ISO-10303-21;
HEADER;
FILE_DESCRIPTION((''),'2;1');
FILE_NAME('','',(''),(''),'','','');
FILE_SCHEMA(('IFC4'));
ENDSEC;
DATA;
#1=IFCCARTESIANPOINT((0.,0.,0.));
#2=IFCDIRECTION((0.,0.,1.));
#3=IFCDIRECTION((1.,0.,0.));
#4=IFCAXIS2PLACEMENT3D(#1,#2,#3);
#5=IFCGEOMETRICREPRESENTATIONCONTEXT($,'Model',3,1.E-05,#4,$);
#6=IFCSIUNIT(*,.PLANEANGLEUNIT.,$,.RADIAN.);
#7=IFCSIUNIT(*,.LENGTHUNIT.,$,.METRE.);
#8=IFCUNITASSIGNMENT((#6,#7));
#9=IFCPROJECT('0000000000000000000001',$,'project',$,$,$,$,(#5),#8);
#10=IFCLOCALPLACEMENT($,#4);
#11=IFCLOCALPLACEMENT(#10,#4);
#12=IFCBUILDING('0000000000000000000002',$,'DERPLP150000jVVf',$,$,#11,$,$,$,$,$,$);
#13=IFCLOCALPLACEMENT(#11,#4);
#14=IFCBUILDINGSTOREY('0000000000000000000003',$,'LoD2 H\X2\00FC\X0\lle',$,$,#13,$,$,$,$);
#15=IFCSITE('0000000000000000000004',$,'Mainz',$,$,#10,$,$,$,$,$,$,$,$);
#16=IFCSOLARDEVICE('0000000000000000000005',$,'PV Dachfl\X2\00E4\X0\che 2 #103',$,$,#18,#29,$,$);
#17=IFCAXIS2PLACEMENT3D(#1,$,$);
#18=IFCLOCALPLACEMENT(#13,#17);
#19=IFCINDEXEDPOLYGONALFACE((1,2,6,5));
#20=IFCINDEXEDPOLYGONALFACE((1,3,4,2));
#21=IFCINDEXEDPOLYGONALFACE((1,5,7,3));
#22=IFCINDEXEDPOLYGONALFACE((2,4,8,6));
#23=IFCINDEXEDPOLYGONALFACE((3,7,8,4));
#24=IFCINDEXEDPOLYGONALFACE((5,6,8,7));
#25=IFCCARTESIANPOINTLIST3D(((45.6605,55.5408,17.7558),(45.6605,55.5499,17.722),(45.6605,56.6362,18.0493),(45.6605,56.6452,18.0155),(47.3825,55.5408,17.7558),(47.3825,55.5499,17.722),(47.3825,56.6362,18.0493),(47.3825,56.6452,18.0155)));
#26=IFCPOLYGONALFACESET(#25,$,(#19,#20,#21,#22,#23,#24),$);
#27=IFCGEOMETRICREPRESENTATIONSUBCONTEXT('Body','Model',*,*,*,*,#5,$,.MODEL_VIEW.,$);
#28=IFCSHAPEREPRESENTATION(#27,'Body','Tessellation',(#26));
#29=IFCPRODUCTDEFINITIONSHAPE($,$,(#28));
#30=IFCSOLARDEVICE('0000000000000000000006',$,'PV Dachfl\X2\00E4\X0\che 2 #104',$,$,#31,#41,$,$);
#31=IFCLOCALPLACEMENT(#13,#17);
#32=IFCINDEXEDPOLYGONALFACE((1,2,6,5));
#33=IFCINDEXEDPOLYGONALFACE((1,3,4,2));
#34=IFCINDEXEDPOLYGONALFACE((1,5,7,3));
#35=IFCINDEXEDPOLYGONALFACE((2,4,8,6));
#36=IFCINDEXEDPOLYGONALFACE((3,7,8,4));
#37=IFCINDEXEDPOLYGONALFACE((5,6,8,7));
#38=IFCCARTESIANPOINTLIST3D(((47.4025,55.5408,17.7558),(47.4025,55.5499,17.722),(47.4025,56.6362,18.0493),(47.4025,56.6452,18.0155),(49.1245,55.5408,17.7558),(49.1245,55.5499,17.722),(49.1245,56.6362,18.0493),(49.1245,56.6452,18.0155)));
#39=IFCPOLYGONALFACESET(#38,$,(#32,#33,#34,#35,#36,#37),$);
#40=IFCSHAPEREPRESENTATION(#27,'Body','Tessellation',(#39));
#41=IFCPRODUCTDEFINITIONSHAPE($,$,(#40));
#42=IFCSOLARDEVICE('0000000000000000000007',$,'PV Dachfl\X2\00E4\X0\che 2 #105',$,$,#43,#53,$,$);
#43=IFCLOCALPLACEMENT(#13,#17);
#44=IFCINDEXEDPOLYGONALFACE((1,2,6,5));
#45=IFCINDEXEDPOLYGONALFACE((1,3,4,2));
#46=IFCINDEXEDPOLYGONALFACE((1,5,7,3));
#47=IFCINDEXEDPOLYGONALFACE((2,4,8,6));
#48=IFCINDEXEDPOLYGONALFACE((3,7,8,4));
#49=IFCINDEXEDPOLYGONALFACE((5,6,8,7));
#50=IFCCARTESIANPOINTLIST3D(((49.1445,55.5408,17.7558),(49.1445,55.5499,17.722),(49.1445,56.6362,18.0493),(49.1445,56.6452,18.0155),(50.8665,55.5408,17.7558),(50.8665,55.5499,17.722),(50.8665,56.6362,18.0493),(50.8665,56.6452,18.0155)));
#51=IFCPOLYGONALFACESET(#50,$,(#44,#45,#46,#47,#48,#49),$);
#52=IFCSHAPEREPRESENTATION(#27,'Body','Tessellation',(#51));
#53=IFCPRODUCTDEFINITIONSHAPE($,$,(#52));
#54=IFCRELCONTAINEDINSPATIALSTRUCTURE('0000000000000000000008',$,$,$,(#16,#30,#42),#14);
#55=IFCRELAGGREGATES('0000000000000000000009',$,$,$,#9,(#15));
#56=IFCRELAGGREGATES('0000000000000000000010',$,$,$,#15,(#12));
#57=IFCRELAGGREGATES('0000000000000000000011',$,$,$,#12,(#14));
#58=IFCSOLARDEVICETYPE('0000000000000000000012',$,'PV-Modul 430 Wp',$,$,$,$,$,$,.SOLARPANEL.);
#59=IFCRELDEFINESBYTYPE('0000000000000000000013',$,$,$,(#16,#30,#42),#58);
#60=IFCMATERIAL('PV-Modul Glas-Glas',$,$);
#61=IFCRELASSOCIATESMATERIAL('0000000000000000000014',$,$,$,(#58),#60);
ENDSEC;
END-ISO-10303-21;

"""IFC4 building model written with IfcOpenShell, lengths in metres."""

from ifc_helpers import new_model, si_unit, frame, frame_2d, origin, origin_with_axes, place, context, subcontext, project, spatial, rectangle, extrude, source, transform, mapped, material, type_object, type_shapes, element, save


model = new_model("IFC4")

# Units and contexts
model_context = context("Model", 3, precision=1e-05, world=origin_with_axes())
body_context = subcontext(model_context, "Body", "Model", "MODEL_VIEW")
ifc_project = project(units=[si_unit("PLANEANGLEUNIT", "RADIAN"), si_unit("LENGTHUNIT", "METRE")], contexts=[model_context])

# Site, building, storey
site_placement = place(None, origin_with_axes())
site = spatial("IfcSite", under=ifc_project, at=site_placement, Name="Mainz")
building_placement = place(site_placement, origin_with_axes())
building = spatial("IfcBuilding", under=site, at=building_placement, Name="DERPLP150000jVVf")
storey_placement = place(building_placement, origin_with_axes())
storey = spatial("IfcBuildingStorey", under=building, at=storey_placement, Name="LoD2 Hülle")

# Solar devices
ifc_material = material(Name="PV-Modul Glas-Glas")
solar_device_type = type_object("IfcSolarDeviceType", Name="PV-Modul 430 Wp", PredefinedType="SOLARPANEL", material=ifc_material)
shared_shape = source(origin_with_axes(), body_context, "Body", "SweptSolid", [
    extrude(rectangle(XDim=1.722, YDim=1.134, at=frame_2d((0.861, 0.567))), origin(), (0.0, 0.0, 1.0), 0.035),
])
type_shapes(solar_device_type, [shared_shape])
for number, where, z_axis, x_axis, name in (
    (1, (45.6605, 55.5499, 17.722), (0.0, -0.258819, 0.965926), (1.0, 0.0, 0.0), "PV Dachfläche 2 #103"),
    (2, (47.4025, 55.5499, 17.722), (0.0, -0.258819, 0.965926), (1.0, 0.0, 0.0), "PV Dachfläche 2 #104"),
    (3, (49.1445, 55.5499, 17.722), (0.0, -0.258819, 0.965926), (1.0, 0.0, 0.0), "PV Dachfläche 2 #105"),
):
    element("IfcSolarDevice", number, at=place(storey_placement, frame(where, z_axis=z_axis, x_axis=x_axis)), inside=storey, type_object=solar_device_type, Name=name, context=body_context, shape_type="MappedRepresentation", body=[
        mapped(shared_shape, transform((0.0, 0.0, 0.0), x_axis=(1.0, 0.0, 0.0), y_axis=(0.0, 1.0, 0.0), z_axis=(0.0, 0.0, 1.0), scale=1.0)),
    ])

save(model, "model.ifc")
